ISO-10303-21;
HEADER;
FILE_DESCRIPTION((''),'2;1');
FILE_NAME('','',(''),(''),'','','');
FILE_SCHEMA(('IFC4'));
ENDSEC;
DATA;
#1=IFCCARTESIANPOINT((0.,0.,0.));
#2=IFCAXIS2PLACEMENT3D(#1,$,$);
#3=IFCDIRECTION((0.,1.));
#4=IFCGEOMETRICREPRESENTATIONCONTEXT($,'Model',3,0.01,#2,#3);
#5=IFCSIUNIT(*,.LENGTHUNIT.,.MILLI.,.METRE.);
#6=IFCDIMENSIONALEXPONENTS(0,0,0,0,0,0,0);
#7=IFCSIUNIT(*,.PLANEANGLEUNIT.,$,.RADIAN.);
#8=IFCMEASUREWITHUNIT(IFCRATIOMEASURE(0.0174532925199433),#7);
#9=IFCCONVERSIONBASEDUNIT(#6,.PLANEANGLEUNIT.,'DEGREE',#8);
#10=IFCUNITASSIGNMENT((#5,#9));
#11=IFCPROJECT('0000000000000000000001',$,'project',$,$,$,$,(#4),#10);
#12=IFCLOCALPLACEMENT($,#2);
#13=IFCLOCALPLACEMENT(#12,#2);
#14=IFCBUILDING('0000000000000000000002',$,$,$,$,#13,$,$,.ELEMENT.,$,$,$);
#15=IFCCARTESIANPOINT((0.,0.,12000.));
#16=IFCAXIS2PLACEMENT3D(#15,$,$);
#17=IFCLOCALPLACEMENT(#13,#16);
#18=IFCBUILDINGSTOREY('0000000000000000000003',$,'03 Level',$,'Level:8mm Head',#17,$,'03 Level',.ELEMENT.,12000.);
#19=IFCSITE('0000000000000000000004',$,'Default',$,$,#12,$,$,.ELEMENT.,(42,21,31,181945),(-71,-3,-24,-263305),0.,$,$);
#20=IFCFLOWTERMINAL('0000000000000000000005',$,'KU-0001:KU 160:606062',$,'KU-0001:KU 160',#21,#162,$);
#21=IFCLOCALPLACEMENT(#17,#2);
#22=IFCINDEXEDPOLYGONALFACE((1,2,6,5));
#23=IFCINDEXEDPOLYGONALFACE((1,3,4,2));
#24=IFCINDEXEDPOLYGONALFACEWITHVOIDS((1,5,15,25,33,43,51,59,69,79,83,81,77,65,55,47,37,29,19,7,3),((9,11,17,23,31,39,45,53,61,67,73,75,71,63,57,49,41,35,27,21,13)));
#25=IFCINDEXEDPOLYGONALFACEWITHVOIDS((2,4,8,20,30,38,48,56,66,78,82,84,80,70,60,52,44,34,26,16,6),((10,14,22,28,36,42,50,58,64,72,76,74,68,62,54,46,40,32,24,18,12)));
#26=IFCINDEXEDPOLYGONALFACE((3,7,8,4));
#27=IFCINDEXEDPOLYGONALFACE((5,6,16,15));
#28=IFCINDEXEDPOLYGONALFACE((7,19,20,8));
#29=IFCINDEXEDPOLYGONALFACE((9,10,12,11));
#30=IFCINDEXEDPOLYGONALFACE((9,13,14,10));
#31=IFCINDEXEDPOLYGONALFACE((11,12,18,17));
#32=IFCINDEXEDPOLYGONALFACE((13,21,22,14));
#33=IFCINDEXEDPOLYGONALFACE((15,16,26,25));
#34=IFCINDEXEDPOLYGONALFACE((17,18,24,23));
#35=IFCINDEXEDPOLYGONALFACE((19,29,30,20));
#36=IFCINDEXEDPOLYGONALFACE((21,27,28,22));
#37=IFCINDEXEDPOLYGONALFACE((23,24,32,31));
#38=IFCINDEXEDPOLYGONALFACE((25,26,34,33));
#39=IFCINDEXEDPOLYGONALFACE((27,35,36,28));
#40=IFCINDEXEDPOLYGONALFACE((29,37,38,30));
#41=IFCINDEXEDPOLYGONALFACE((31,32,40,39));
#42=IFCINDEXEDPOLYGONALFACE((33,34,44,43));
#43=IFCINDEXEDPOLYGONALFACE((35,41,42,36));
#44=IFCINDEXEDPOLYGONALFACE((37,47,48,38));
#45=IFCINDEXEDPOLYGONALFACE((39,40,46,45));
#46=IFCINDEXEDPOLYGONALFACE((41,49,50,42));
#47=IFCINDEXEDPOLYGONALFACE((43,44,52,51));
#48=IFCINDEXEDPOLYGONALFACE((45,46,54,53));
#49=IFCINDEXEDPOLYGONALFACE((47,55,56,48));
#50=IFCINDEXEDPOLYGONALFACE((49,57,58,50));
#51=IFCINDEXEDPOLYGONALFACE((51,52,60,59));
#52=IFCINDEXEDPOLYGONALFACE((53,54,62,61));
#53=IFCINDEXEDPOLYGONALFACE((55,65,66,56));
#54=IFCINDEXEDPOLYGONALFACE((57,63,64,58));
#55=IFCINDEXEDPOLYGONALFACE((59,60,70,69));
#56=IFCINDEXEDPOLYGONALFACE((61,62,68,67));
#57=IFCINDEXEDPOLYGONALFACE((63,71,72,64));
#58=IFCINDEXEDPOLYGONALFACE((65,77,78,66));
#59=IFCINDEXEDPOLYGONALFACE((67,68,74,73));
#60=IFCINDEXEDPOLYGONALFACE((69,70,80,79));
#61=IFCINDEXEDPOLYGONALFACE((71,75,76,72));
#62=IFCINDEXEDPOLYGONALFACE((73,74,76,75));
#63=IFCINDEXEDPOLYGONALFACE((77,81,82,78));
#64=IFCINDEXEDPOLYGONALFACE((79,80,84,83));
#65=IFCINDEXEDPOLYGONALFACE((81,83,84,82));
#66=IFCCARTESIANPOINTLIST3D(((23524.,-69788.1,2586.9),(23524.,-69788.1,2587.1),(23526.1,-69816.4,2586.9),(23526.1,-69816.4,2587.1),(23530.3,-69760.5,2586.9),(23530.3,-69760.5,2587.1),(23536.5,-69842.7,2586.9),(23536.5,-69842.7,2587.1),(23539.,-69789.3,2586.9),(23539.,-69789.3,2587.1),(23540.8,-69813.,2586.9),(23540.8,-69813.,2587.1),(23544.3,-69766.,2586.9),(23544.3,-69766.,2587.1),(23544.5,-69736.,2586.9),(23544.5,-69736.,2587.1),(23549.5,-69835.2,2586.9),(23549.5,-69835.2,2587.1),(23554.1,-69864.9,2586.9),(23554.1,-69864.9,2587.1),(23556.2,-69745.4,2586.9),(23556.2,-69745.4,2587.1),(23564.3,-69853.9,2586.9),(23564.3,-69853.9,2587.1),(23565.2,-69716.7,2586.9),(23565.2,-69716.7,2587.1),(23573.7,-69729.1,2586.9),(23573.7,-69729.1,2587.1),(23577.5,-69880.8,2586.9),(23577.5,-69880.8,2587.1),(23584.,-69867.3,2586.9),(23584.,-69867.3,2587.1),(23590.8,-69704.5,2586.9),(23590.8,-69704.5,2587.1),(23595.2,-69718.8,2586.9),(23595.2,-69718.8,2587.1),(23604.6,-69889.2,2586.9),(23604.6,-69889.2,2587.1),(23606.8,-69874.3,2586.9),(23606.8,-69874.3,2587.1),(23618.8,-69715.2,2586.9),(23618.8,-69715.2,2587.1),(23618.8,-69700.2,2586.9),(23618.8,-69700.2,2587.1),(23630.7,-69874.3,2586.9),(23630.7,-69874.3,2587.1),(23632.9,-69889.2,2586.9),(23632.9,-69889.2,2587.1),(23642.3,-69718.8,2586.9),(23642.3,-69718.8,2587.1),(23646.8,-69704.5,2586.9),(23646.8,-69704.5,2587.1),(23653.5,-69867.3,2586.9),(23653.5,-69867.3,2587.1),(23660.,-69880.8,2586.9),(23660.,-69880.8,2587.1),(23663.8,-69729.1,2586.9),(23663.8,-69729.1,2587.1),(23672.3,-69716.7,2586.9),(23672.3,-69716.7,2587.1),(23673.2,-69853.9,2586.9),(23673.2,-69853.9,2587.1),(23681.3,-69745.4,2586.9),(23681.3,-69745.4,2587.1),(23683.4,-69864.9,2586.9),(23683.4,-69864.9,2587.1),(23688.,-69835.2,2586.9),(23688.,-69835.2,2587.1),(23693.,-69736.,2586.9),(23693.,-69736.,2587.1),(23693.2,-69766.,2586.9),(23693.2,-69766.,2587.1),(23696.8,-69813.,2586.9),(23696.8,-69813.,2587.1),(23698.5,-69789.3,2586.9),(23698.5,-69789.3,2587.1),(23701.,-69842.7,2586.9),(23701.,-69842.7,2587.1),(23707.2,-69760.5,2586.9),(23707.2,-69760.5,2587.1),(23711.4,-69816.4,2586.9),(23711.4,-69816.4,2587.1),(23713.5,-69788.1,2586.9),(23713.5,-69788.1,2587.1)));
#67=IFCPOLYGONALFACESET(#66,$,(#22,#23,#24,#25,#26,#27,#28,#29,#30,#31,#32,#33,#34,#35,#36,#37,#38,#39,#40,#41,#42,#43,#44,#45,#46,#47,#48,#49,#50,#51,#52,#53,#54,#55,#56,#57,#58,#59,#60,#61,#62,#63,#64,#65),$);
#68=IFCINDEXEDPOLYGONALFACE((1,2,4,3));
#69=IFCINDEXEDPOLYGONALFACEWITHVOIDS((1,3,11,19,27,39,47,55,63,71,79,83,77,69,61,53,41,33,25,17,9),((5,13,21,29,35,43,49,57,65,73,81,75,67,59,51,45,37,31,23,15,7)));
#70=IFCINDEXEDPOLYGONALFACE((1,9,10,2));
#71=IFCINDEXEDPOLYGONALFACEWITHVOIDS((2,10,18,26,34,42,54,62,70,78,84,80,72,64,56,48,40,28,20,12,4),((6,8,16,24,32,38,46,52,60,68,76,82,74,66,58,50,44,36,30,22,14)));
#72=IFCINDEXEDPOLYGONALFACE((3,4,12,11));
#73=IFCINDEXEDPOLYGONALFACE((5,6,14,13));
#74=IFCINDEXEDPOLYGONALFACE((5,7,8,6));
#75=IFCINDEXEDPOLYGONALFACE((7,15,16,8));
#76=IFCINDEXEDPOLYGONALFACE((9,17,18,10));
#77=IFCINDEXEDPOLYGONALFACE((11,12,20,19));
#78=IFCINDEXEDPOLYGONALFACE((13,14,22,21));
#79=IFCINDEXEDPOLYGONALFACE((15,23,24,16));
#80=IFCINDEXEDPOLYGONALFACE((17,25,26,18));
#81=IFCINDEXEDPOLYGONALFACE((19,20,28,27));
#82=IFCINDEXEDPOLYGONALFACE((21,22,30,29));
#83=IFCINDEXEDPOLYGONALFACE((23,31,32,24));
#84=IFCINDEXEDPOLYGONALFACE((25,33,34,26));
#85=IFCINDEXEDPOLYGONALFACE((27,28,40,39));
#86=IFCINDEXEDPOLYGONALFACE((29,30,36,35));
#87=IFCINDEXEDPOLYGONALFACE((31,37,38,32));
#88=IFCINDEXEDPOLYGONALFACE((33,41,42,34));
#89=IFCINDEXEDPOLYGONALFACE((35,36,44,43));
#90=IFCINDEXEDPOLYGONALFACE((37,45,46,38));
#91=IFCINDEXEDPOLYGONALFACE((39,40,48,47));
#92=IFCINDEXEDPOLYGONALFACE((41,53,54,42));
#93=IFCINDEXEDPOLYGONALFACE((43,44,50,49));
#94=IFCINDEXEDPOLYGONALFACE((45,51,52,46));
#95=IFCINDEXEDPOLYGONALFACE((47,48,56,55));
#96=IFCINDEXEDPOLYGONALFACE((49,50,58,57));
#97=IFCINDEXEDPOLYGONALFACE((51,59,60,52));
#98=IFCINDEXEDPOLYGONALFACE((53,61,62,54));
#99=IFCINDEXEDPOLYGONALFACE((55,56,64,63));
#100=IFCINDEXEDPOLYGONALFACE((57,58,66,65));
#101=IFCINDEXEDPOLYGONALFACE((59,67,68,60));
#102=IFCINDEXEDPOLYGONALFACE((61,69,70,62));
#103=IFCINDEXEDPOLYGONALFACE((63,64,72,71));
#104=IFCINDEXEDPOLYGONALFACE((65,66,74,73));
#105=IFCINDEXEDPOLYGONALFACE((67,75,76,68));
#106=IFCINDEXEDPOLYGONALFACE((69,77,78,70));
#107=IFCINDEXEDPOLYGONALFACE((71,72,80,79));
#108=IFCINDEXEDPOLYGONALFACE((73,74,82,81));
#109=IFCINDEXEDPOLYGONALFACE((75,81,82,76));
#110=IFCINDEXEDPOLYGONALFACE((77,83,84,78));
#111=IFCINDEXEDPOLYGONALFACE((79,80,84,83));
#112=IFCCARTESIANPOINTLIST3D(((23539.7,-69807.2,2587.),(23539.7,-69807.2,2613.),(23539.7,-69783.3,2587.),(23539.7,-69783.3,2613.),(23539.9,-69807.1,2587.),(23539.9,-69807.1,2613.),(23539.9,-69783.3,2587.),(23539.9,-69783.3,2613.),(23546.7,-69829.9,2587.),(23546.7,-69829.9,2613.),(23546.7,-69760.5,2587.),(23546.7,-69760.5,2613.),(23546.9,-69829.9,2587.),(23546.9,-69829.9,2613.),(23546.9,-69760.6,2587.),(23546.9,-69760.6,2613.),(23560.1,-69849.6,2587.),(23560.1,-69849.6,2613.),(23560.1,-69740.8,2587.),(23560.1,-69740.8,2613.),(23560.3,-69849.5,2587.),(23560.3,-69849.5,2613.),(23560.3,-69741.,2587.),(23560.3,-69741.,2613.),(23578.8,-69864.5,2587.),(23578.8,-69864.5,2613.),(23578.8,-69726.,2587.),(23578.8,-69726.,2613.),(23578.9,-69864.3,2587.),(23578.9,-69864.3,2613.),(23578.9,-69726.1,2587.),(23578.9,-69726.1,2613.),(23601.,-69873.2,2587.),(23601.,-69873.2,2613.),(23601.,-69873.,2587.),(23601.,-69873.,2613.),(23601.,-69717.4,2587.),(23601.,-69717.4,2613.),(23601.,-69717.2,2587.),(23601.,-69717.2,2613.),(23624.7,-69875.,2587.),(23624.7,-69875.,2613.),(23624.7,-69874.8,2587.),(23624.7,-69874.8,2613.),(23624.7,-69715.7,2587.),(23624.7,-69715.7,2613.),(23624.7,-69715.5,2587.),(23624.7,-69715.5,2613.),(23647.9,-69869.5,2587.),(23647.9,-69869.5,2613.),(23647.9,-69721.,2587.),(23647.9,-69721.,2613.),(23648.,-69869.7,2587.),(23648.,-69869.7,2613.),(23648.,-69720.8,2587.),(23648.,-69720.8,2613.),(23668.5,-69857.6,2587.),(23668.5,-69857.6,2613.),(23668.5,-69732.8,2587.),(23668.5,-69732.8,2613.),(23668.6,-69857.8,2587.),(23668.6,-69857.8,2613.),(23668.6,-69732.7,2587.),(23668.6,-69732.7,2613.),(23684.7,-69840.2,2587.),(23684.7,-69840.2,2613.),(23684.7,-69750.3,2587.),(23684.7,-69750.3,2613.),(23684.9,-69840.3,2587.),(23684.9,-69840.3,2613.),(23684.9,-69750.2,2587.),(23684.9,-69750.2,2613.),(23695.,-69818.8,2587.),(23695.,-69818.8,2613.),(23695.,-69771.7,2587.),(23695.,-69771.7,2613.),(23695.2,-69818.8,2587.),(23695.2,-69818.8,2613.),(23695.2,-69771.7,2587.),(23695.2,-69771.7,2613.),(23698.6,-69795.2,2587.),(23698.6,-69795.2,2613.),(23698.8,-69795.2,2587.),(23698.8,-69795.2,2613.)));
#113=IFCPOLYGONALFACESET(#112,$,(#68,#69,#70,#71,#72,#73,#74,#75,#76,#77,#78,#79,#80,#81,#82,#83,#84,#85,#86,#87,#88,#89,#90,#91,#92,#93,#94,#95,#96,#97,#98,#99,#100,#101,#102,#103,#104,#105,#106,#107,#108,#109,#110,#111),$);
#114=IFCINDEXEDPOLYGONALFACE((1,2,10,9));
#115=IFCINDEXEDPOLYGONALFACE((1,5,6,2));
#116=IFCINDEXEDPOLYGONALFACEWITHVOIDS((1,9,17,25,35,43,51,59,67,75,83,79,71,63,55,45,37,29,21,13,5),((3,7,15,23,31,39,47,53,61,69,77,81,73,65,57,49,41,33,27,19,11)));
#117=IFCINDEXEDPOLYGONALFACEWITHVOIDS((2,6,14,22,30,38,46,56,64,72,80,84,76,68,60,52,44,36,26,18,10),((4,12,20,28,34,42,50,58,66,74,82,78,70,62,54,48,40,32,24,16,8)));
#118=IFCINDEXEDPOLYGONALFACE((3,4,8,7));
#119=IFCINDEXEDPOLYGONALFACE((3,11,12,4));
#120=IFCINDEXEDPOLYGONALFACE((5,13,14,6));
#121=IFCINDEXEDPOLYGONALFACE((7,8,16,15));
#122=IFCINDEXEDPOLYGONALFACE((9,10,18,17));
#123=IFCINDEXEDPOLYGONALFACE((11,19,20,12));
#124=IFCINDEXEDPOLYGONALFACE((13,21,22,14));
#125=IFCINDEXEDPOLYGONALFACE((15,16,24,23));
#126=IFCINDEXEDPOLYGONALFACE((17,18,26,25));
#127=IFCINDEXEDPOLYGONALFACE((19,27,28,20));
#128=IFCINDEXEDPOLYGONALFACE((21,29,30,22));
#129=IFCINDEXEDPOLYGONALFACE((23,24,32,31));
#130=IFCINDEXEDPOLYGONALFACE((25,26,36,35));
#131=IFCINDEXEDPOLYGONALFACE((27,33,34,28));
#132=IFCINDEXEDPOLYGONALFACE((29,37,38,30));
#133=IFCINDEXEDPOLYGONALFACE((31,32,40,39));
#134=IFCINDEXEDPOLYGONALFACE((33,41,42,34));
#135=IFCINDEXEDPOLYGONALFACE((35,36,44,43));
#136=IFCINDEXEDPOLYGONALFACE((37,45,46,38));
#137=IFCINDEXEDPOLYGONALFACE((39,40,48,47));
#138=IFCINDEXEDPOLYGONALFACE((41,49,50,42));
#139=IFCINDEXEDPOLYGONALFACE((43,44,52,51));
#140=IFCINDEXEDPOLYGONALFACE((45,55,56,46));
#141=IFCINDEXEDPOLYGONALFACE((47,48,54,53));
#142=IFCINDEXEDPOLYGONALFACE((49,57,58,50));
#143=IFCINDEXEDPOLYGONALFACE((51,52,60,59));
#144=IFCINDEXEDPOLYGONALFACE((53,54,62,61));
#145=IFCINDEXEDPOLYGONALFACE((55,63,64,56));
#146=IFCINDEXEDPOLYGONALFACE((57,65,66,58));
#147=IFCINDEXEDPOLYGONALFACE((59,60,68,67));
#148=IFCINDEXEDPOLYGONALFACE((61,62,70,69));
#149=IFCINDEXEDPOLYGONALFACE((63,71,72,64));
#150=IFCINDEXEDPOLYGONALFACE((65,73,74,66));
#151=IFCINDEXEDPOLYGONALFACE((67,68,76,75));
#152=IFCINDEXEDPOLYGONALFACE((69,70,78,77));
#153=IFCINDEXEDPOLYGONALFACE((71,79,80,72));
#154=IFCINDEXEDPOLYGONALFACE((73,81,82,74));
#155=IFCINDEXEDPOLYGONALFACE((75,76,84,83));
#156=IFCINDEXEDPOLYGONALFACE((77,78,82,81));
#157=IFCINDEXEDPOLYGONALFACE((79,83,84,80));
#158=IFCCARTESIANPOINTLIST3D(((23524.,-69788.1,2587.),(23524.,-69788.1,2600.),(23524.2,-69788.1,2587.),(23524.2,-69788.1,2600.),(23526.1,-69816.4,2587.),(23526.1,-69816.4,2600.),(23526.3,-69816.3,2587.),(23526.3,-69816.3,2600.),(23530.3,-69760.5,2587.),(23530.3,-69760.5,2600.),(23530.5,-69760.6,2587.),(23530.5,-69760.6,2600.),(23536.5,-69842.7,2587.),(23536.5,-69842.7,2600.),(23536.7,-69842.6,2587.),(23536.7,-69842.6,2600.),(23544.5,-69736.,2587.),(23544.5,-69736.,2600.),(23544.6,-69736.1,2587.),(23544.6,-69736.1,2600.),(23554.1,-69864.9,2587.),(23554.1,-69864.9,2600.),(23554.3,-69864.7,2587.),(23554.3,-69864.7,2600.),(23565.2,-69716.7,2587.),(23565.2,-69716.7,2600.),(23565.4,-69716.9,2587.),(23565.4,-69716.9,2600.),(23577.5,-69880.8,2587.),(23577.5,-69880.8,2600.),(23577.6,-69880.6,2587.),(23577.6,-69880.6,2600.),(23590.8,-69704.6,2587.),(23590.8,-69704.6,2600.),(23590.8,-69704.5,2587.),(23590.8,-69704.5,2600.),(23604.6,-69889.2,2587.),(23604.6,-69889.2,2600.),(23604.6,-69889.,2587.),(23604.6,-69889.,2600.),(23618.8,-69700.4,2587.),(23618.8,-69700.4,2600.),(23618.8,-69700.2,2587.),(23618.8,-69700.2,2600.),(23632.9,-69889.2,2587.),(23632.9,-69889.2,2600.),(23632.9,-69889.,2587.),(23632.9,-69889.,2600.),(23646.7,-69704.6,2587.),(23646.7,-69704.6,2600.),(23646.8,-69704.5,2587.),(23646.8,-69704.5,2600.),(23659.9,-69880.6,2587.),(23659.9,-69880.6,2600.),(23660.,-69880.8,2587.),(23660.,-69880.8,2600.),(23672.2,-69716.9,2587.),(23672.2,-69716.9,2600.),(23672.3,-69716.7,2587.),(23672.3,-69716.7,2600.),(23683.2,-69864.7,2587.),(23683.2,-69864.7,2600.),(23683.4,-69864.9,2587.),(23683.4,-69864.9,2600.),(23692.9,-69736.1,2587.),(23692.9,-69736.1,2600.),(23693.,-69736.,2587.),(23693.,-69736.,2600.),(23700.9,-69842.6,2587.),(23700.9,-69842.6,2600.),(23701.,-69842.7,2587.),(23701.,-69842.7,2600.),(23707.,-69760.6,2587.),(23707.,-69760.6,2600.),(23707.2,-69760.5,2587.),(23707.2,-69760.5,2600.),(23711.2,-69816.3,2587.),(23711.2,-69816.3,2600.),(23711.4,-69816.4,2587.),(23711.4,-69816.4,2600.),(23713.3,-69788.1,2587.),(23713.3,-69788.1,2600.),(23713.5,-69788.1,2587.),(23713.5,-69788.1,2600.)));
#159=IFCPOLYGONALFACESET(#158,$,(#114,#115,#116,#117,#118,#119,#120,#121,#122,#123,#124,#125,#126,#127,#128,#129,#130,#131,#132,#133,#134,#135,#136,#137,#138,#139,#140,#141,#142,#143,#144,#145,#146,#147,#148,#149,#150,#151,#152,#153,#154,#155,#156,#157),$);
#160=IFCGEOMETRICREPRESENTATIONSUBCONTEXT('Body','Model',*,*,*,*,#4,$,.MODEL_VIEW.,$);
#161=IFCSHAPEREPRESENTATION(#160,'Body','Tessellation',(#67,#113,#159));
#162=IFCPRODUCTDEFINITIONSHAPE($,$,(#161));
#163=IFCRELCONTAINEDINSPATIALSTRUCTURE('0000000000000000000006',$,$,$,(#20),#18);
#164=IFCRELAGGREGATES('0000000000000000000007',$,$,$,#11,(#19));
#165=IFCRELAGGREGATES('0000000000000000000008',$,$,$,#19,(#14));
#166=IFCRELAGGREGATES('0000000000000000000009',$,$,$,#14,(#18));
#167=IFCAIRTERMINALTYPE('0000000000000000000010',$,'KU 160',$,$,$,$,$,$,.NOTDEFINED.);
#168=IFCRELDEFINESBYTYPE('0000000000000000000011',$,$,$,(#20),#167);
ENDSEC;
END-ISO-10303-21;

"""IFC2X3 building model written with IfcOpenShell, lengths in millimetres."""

from ifc_helpers import new_model, entity, si_unit, converted_unit, direction, frame, frame_2d, origin, place, context, subcontext, project, spatial, hollow_circle, extrude, source, transform, mapped, type_object, type_shapes, element, save


model = new_model("IFC2X3")

# Units and contexts
model_context = context("Model", 3, precision=0.01, world=origin(), true_north=direction((0.0, 1.0)))
body_context = subcontext(model_context, "Body", "Model", "MODEL_VIEW")
ifc_project = project(units=[si_unit("LENGTHUNIT", "METRE", prefix="MILLI"), converted_unit("PLANEANGLEUNIT", "DEGREE", entity("IfcRatioMeasure", 0.0174532925199433), si_unit("PLANEANGLEUNIT", "RADIAN"), dimensions=[0, 0, 0, 0, 0, 0, 0])], contexts=[model_context])

# Site, building, storey
site_placement = place(None, origin())
site = spatial("IfcSite", under=ifc_project, at=site_placement, Name="Default", CompositionType="ELEMENT", RefLatitude=(42, 21, 31, 181945), RefLongitude=(-71, -3, -24, -263305), RefElevation=0.0)
building_placement = place(site_placement, origin())
building = spatial("IfcBuilding", under=site, at=building_placement, CompositionType="ELEMENT")
storey_placement = place(building_placement, frame((0.0, 0.0, 12000.0)))
storey = spatial("IfcBuildingStorey", under=building, at=storey_placement, Name="03 Level", ObjectType="Level:8mm Head", LongName="03 Level", CompositionType="ELEMENT", Elevation=12000.0)

# Flow terminal
air_terminal_type_1 = type_object("IfcAirTerminalType", Name="KU 160", PredefinedType="NOTDEFINED")
shared_shape_1 = source(origin(), body_context, "Body", "SweptSolid", [
    extrude(hollow_circle(Radius=95.0, WallThickness=15.0, at=frame_2d((0.0, 0.0), x_axis=(1.0, 0.0))), frame((12.9, 0.0, 0.0), z_axis=(1.0, 0.0, 0.0), x_axis=(0.0, 1.0, 0.0)), (0.0, 0.0, 1.0), 0.2),
    extrude(hollow_circle(Radius=80.0, WallThickness=0.2, at=frame_2d((0.0, 0.0), x_axis=(1.0, 0.0))), frame((-13.0, 0.0, 0.0), z_axis=(1.0, 0.0, 0.0), x_axis=(0.0, 0.0, 1.0)), (0.0, 0.0, 1.0), 26.0),
    extrude(hollow_circle(Radius=95.0, WallThickness=0.2, at=frame_2d((0.0, 0.0), x_axis=(1.0, 0.0))), frame((0.0, 0.0, 0.0), z_axis=(1.0, 0.0, 0.0), x_axis=(0.0, 1.0, 0.0)), (0.0, 0.0, 1.0), 13.0),
])
type_shapes(air_terminal_type_1, [shared_shape_1])
for number, where, z_axis, x_axis, name in (
    (1, (23618.8, -69795.2, 2600.0), (1.0, 0.0, 0.0), (0.0, 0.0, -1.0), "KU-0001:KU 160:606062"),
):
    element("IfcFlowTerminal", number, at=place(storey_placement, frame(where, z_axis=z_axis, x_axis=x_axis)), inside=storey, type_object=air_terminal_type_1, Name=name, ObjectType="KU-0001:KU 160", context=body_context, shape_type="MappedRepresentation", body=[
        mapped(shared_shape_1, transform((0.0, 0.0, 0.0), scale=1.0)),
    ])

save(model, "model.ifc")
